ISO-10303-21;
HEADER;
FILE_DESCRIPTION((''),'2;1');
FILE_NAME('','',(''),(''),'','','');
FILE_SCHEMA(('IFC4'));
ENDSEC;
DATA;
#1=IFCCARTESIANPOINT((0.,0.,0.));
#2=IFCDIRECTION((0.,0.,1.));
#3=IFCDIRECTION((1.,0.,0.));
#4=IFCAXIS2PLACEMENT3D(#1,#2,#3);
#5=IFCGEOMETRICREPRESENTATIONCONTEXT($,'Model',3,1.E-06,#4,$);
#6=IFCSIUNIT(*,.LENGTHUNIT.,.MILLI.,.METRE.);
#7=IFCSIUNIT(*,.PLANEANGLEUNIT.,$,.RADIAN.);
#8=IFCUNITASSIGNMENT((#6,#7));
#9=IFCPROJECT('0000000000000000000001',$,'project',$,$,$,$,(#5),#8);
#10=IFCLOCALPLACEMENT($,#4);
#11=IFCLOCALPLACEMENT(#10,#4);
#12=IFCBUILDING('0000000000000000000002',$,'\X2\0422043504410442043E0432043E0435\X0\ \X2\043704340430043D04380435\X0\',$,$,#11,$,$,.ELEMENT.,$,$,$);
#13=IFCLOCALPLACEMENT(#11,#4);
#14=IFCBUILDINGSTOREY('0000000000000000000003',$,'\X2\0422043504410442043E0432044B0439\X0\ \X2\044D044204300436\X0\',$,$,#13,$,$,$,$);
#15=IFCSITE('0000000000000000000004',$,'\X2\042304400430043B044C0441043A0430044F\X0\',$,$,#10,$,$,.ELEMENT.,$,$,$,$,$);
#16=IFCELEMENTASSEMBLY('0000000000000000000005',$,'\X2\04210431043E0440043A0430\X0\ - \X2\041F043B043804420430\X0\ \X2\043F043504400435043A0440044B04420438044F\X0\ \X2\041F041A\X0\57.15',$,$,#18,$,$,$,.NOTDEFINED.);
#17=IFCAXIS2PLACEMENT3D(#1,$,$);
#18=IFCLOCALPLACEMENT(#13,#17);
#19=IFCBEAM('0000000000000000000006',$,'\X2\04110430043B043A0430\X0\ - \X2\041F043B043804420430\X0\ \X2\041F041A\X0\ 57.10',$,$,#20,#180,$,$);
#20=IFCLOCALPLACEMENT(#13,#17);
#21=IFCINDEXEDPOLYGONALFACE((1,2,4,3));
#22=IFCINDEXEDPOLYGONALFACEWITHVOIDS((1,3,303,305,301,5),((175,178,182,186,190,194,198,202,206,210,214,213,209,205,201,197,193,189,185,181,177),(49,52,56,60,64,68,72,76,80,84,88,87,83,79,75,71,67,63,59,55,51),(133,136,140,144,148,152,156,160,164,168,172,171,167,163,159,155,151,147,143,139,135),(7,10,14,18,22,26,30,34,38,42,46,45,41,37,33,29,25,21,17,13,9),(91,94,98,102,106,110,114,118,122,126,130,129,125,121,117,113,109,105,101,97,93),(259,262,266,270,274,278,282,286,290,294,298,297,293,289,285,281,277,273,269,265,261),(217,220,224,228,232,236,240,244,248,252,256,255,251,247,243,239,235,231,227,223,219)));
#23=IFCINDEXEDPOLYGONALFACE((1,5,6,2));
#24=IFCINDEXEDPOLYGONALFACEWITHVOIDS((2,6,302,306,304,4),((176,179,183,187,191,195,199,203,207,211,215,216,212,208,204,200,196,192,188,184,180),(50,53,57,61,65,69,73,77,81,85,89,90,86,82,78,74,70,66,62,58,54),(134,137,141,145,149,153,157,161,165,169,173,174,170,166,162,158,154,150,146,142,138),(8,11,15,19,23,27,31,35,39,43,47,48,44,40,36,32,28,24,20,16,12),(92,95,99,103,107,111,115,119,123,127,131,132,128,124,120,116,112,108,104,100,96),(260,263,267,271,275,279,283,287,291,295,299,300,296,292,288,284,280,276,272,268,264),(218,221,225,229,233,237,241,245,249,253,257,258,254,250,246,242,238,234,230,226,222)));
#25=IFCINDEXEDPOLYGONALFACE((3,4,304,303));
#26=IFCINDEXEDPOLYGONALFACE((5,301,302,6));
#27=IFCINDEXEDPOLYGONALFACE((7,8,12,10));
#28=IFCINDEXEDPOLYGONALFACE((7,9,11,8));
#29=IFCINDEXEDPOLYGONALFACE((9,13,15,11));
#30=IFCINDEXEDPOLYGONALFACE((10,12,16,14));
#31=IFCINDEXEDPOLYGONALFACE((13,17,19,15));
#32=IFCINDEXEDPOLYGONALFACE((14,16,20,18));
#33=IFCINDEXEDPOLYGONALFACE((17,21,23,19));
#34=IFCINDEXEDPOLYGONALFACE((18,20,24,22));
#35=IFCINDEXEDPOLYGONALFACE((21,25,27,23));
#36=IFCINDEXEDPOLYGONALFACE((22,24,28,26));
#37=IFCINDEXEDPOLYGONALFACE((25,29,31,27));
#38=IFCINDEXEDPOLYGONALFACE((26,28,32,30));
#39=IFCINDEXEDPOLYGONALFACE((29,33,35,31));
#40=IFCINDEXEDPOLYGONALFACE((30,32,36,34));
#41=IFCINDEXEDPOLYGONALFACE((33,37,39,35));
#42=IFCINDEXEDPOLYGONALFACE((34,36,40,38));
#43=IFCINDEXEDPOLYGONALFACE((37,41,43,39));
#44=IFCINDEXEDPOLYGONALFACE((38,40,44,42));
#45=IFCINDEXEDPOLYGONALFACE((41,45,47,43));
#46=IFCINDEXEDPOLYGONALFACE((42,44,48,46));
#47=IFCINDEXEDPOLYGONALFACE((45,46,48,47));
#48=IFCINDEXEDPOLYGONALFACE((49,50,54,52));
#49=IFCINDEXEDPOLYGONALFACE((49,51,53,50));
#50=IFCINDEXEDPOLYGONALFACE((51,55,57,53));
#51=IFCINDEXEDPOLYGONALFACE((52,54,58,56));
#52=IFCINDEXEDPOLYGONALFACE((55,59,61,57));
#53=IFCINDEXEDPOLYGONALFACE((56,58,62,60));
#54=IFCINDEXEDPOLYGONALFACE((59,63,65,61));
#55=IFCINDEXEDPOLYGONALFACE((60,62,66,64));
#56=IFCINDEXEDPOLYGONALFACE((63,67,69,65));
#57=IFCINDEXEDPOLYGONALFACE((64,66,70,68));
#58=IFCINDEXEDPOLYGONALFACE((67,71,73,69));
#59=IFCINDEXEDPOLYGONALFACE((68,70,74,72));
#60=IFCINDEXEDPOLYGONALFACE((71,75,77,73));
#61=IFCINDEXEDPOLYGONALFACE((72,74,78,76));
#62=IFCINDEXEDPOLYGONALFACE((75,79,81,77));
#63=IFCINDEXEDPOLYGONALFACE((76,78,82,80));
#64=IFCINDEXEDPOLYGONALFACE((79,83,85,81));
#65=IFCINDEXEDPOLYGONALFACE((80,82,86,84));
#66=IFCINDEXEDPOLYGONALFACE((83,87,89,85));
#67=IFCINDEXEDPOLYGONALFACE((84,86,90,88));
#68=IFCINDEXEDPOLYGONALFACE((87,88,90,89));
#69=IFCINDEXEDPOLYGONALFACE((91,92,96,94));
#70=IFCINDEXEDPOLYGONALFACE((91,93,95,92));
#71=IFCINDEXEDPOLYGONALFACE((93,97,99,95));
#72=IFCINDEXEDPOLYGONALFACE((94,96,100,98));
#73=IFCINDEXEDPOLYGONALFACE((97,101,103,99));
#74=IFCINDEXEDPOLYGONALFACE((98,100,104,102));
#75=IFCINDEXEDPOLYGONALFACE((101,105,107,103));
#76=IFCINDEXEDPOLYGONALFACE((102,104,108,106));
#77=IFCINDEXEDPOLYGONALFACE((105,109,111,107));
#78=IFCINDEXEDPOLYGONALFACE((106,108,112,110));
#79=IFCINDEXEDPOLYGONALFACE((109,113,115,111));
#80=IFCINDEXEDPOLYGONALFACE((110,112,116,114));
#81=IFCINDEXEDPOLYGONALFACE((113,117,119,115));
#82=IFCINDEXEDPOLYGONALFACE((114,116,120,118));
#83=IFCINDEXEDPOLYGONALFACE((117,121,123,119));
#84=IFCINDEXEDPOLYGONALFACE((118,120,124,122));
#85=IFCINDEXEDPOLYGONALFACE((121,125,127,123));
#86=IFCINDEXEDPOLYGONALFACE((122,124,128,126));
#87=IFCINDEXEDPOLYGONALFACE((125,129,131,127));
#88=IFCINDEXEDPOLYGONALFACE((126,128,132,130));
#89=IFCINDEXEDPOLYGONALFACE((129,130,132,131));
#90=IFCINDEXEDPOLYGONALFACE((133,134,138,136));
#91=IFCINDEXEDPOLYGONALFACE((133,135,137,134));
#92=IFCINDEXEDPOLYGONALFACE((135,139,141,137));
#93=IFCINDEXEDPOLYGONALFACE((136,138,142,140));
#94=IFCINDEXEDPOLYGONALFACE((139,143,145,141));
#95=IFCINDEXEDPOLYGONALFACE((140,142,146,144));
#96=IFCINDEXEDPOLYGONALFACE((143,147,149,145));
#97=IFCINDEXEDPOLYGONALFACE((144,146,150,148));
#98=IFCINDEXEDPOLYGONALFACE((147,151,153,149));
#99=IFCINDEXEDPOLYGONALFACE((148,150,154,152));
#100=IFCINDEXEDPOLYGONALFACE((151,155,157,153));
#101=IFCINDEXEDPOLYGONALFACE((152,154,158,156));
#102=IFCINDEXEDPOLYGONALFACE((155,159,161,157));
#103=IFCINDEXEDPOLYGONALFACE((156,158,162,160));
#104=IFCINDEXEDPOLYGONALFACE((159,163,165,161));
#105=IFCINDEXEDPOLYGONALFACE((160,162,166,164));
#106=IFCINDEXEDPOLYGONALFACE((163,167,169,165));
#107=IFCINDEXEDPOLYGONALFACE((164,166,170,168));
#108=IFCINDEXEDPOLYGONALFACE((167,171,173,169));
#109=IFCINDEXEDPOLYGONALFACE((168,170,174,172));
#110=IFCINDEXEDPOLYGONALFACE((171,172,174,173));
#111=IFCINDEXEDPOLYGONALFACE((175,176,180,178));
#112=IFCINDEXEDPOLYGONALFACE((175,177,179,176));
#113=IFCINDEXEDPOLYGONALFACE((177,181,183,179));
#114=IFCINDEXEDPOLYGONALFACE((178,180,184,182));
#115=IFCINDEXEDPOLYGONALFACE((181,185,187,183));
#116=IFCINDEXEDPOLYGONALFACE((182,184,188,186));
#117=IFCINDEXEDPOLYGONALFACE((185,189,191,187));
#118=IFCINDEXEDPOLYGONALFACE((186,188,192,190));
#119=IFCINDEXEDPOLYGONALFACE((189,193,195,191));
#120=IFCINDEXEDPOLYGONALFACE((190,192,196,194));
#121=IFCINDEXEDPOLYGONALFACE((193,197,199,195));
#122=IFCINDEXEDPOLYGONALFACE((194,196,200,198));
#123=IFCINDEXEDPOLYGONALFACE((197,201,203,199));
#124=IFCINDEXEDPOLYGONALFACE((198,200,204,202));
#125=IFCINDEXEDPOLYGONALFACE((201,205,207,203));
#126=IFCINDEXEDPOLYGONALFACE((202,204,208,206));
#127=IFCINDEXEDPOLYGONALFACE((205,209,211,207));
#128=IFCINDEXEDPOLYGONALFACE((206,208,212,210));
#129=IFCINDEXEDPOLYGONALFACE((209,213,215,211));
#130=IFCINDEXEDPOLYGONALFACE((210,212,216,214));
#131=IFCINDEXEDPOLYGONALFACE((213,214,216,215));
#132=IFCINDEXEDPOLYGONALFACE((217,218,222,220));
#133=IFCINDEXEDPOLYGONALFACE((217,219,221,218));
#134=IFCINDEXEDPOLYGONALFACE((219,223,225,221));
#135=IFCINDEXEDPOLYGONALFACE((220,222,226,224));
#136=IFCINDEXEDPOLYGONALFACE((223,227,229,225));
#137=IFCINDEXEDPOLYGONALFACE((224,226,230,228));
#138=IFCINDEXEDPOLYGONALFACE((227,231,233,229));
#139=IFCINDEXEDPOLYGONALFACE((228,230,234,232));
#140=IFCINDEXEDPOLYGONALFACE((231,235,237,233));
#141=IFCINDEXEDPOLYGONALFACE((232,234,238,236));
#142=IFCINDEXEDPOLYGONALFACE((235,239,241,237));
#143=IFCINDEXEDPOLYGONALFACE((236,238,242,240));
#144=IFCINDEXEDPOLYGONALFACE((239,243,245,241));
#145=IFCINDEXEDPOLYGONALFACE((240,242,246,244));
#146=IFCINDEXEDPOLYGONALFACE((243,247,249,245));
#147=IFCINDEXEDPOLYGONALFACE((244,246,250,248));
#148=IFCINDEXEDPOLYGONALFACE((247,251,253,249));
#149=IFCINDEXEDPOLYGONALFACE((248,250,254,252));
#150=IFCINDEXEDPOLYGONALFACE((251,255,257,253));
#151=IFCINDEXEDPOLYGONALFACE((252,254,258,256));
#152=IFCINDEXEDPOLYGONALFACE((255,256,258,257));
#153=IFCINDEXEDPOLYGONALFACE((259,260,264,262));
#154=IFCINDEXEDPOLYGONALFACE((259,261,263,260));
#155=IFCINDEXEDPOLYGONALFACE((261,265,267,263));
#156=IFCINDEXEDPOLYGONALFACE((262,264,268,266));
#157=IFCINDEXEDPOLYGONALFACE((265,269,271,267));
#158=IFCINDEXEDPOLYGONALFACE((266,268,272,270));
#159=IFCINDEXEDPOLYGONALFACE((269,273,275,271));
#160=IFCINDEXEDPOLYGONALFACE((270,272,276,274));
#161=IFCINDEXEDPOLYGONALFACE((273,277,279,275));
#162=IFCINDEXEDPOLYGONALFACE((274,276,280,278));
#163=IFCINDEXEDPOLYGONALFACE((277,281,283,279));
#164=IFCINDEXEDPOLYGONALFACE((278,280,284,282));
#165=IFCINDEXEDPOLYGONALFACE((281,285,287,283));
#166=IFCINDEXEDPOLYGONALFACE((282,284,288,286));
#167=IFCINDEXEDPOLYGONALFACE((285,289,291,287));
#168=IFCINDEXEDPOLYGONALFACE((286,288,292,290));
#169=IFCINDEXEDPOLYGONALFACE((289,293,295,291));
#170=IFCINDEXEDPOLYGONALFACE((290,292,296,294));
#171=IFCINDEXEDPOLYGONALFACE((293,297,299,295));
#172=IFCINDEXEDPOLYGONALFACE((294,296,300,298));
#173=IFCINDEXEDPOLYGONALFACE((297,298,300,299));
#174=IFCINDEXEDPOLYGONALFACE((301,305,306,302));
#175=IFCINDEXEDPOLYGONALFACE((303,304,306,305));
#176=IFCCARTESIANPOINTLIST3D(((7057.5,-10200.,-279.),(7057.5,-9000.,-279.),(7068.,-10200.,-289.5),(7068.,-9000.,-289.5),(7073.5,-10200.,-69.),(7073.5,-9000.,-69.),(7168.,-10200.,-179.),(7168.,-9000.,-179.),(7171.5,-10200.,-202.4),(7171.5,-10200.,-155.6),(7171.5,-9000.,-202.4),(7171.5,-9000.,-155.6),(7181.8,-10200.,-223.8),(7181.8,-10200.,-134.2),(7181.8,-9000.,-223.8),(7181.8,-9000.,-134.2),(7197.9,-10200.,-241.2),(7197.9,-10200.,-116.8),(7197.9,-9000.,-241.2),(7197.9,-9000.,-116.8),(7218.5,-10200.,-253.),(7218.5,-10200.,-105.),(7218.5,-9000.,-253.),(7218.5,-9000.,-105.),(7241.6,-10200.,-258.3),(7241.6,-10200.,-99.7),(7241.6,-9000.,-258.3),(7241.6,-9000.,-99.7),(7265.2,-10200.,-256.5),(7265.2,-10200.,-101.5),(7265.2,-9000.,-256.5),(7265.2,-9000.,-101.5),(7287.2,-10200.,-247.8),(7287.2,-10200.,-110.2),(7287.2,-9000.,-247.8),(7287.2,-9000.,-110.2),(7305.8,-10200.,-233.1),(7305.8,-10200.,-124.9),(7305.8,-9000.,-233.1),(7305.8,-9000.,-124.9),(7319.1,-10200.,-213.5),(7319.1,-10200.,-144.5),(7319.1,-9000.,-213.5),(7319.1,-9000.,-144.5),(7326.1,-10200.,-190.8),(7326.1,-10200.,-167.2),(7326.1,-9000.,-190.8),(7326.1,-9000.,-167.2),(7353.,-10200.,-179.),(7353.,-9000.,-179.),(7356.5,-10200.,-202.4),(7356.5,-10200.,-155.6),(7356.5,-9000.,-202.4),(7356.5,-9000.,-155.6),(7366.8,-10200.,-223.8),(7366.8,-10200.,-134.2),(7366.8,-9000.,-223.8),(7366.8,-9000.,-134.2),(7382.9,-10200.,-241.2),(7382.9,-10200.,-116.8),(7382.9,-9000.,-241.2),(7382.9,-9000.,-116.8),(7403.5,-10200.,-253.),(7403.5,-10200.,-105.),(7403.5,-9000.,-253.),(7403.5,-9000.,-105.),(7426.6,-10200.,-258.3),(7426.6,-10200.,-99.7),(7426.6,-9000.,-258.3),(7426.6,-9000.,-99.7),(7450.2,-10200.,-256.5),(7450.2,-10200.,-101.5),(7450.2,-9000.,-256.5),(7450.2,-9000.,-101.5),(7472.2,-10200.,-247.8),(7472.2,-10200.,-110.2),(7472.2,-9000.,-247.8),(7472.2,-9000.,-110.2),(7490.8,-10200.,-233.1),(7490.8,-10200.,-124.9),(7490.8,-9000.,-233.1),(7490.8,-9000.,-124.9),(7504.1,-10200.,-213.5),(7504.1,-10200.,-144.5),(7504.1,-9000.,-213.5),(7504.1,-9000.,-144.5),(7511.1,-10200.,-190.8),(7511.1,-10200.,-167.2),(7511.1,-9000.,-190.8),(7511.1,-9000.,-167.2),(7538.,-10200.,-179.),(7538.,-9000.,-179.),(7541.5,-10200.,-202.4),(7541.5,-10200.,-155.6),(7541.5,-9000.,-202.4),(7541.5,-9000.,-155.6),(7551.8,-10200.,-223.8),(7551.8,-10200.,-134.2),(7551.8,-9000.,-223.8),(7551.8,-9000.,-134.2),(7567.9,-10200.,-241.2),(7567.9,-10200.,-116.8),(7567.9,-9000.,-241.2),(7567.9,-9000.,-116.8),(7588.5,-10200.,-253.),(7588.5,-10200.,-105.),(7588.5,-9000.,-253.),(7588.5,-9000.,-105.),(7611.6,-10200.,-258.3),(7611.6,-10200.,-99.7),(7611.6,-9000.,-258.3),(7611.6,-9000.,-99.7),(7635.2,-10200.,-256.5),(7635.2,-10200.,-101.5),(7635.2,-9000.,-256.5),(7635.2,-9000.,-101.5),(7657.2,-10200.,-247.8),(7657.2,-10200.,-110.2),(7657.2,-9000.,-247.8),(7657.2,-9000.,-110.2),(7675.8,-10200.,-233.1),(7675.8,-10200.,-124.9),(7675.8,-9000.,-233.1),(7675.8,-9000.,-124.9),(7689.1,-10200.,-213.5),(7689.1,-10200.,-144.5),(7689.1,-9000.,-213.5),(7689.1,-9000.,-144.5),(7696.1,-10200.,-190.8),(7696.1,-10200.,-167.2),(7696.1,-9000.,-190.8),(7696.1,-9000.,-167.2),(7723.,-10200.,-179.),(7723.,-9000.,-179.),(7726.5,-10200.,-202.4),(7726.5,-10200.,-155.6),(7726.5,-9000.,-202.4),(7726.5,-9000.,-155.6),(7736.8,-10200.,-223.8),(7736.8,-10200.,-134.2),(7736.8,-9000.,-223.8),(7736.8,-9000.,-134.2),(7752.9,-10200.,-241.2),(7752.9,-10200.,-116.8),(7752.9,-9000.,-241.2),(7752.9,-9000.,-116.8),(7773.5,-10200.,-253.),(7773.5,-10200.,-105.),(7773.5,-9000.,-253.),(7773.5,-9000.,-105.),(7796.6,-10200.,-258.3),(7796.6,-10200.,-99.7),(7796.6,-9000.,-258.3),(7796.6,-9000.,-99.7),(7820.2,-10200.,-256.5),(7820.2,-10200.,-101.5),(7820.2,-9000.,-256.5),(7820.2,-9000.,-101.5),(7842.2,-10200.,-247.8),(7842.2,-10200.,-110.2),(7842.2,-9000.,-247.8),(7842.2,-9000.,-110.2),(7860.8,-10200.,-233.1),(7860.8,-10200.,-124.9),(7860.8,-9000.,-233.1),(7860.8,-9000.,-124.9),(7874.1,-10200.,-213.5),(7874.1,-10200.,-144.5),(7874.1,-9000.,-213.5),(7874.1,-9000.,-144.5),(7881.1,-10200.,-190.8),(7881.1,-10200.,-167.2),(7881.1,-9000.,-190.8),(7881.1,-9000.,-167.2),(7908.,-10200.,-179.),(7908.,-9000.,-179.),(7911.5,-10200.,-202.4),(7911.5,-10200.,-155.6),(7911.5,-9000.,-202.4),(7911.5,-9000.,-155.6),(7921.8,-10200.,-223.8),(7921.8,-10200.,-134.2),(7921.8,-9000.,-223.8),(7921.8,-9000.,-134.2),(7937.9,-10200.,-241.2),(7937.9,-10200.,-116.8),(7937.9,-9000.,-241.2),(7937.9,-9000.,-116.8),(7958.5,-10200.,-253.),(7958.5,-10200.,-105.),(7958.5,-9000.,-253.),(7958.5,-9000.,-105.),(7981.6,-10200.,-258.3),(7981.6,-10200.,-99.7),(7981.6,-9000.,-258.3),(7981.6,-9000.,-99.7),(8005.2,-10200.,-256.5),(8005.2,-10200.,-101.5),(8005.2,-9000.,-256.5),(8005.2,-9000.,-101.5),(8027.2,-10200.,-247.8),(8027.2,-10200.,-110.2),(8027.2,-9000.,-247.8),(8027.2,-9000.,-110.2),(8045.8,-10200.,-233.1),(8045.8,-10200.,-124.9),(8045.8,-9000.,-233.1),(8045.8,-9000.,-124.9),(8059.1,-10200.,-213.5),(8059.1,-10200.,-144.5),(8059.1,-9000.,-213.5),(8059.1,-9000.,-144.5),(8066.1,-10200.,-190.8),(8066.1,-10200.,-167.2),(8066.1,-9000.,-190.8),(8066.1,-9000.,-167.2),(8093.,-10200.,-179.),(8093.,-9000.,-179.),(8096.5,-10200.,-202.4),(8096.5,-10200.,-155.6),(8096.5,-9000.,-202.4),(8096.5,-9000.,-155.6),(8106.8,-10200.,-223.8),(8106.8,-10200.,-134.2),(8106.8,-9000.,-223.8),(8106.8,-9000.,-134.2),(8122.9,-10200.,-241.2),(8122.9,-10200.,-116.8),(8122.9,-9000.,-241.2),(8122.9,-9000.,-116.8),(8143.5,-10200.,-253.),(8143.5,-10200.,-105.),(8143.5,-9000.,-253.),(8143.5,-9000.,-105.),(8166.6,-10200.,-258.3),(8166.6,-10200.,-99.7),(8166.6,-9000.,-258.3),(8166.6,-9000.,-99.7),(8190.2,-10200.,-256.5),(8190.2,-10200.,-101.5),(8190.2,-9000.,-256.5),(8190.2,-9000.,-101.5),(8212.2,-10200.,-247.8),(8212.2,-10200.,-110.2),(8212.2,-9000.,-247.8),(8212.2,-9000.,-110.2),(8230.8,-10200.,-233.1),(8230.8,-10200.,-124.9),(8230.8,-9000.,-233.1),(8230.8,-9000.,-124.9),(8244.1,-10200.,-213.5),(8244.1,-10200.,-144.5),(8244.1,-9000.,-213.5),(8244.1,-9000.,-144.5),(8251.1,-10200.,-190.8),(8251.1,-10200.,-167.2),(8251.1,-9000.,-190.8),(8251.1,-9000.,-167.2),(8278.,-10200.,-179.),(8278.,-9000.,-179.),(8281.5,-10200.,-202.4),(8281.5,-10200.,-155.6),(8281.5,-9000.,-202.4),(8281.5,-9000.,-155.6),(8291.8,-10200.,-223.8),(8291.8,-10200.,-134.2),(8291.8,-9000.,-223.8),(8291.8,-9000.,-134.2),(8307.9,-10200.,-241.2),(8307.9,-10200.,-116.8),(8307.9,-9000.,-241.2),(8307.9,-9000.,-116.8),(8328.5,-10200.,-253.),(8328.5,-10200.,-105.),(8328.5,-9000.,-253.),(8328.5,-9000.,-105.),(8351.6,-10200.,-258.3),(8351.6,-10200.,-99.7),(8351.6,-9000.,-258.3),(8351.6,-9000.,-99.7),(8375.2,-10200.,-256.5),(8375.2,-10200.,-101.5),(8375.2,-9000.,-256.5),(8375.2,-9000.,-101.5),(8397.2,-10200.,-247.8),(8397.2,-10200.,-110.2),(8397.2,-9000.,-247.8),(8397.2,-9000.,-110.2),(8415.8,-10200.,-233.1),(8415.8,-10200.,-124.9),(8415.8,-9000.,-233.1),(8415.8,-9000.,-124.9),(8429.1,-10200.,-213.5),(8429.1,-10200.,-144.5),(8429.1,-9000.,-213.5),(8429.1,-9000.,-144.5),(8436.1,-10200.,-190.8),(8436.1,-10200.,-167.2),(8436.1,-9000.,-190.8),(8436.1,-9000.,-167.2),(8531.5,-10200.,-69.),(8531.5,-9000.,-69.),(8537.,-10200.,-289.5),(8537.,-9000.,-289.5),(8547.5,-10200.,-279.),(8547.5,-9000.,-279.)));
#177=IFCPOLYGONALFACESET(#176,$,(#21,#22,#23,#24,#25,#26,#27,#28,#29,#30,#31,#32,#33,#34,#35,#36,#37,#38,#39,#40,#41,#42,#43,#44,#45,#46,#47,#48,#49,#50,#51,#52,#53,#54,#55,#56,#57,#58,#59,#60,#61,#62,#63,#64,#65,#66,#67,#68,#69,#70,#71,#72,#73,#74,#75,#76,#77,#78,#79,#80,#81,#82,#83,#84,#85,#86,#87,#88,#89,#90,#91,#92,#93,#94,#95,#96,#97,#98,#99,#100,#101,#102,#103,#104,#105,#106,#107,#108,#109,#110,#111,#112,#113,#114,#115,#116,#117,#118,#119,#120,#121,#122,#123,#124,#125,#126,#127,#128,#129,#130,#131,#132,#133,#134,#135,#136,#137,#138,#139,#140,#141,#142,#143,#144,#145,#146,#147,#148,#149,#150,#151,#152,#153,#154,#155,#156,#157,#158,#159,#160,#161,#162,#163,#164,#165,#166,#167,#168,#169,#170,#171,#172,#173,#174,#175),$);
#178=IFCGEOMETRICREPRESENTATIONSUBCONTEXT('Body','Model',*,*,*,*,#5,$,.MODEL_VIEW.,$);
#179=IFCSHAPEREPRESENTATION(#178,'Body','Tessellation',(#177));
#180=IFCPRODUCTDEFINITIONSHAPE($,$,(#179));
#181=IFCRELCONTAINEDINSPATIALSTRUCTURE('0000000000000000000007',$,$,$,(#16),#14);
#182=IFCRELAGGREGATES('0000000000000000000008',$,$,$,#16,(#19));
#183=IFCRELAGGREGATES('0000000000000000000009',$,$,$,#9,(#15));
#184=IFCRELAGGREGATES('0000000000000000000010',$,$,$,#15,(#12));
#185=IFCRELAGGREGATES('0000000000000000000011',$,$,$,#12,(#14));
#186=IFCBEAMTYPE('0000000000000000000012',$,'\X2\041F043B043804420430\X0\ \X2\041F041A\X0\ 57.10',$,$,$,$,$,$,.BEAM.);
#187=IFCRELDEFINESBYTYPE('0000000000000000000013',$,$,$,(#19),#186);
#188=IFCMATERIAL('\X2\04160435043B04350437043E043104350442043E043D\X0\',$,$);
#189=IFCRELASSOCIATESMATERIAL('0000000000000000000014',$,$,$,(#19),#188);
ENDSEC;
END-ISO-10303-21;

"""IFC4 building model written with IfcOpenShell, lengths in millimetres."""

from ifc_helpers import new_model, si_unit, frame, frame_2d, origin_with_axes, place, context, subcontext, project, spatial, line, indexed_curve, circle_curve, outline, extrude, source, transform, mapped, material, type_object, element, aggregate, save


model = new_model("IFC4")

# Units and contexts
model_context = context("Model", 3, precision=1e-06, world=origin_with_axes())
body_context = subcontext(model_context, "Body", "Model", "MODEL_VIEW")
ifc_project = project(units=[si_unit("LENGTHUNIT", "METRE", prefix="MILLI"), si_unit("PLANEANGLEUNIT", "RADIAN")], contexts=[model_context])

# Site, building, storey
site_placement = place(None, origin_with_axes())
site = spatial("IfcSite", under=ifc_project, at=site_placement, Name="Уральская", CompositionType="ELEMENT")
building_placement = place(site_placement, origin_with_axes())
building = spatial("IfcBuilding", under=site, at=building_placement, Name="Тестовое здание", CompositionType="ELEMENT")
storey_placement = place(building_placement, origin_with_axes())
storey = spatial("IfcBuildingStorey", under=building, at=storey_placement, Name="Тестовый этаж")

# Element assembly, beam
ifc_material_1 = material(Name="Железобетон")
beam_type_1 = type_object("IfcBeamType", Name="Плита ПК 57.10", PredefinedType="BEAM")
shared_shape_1 = source(origin_with_axes(), body_context, "Body", "SweptSolid", [
    extrude(outline(indexed_curve([(-729.0, 0.0), (-745.0, -210.0), (-734.5, -220.5), (734.5, -220.5), (745.0, -210.0), (729.0, 0.0)], segments=[line(1, 2), line(2, 3), line(3, 4), line(4, 5), line(5, 6), line(6, 1)]), holes=[circle_curve(frame_2d((555.0, -110.0), x_axis=(1.0, 0.0)), 79.5), circle_curve(frame_2d((370.0, -110.0), x_axis=(1.0, 0.0)), 79.5), circle_curve(frame_2d((185.0, -110.0), x_axis=(1.0, 0.0)), 79.5), circle_curve(frame_2d((-555.0, -110.0), x_axis=(1.0, 0.0)), 79.5), circle_curve(frame_2d((-370.0, -110.0), x_axis=(1.0, 0.0)), 79.5), circle_curve(frame_2d((-185.0, -110.0), x_axis=(1.0, 0.0)), 79.5), circle_curve(frame_2d((0.0, -110.0), x_axis=(1.0, 0.0)), 79.5)]), origin_with_axes(), (0.0, 0.0, -1.0), 1200.0),
])
assembly_1_placement = place(storey_placement, frame((7802.5, -9750.0, -69.0), z_axis=(0.0, 0.0, 1.0), x_axis=(1.0, 0.0, 0.0)))
assembly_1 = element("IfcElementAssembly", 1, at=assembly_1_placement, inside=storey, Name="Сборка - Плита перекрытия ПК57.15", PredefinedType="NOTDEFINED")
beam_1_placement = place(assembly_1_placement, frame((0.0, 750.0, 0.0), z_axis=(0.0, 1.0, 0.0), x_axis=(-1.0, 0.0, 0.0)))
beam_1 = element("IfcBeam", 2, at=beam_1_placement, type_object=beam_type_1, material=ifc_material_1, Name="Балка - Плита ПК 57.10", context=body_context, shape_type="MappedRepresentation", body=[
    mapped(shared_shape_1, transform((0.0, 0.0, 0.0), x_axis=(1.0, 0.0, 0.0), y_axis=(0.0, 1.0, 0.0), z_axis=(0.0, 0.0, 1.0), scale=1.0)),
])
aggregate(assembly_1, [beam_1])

save(model, "model.ifc")
